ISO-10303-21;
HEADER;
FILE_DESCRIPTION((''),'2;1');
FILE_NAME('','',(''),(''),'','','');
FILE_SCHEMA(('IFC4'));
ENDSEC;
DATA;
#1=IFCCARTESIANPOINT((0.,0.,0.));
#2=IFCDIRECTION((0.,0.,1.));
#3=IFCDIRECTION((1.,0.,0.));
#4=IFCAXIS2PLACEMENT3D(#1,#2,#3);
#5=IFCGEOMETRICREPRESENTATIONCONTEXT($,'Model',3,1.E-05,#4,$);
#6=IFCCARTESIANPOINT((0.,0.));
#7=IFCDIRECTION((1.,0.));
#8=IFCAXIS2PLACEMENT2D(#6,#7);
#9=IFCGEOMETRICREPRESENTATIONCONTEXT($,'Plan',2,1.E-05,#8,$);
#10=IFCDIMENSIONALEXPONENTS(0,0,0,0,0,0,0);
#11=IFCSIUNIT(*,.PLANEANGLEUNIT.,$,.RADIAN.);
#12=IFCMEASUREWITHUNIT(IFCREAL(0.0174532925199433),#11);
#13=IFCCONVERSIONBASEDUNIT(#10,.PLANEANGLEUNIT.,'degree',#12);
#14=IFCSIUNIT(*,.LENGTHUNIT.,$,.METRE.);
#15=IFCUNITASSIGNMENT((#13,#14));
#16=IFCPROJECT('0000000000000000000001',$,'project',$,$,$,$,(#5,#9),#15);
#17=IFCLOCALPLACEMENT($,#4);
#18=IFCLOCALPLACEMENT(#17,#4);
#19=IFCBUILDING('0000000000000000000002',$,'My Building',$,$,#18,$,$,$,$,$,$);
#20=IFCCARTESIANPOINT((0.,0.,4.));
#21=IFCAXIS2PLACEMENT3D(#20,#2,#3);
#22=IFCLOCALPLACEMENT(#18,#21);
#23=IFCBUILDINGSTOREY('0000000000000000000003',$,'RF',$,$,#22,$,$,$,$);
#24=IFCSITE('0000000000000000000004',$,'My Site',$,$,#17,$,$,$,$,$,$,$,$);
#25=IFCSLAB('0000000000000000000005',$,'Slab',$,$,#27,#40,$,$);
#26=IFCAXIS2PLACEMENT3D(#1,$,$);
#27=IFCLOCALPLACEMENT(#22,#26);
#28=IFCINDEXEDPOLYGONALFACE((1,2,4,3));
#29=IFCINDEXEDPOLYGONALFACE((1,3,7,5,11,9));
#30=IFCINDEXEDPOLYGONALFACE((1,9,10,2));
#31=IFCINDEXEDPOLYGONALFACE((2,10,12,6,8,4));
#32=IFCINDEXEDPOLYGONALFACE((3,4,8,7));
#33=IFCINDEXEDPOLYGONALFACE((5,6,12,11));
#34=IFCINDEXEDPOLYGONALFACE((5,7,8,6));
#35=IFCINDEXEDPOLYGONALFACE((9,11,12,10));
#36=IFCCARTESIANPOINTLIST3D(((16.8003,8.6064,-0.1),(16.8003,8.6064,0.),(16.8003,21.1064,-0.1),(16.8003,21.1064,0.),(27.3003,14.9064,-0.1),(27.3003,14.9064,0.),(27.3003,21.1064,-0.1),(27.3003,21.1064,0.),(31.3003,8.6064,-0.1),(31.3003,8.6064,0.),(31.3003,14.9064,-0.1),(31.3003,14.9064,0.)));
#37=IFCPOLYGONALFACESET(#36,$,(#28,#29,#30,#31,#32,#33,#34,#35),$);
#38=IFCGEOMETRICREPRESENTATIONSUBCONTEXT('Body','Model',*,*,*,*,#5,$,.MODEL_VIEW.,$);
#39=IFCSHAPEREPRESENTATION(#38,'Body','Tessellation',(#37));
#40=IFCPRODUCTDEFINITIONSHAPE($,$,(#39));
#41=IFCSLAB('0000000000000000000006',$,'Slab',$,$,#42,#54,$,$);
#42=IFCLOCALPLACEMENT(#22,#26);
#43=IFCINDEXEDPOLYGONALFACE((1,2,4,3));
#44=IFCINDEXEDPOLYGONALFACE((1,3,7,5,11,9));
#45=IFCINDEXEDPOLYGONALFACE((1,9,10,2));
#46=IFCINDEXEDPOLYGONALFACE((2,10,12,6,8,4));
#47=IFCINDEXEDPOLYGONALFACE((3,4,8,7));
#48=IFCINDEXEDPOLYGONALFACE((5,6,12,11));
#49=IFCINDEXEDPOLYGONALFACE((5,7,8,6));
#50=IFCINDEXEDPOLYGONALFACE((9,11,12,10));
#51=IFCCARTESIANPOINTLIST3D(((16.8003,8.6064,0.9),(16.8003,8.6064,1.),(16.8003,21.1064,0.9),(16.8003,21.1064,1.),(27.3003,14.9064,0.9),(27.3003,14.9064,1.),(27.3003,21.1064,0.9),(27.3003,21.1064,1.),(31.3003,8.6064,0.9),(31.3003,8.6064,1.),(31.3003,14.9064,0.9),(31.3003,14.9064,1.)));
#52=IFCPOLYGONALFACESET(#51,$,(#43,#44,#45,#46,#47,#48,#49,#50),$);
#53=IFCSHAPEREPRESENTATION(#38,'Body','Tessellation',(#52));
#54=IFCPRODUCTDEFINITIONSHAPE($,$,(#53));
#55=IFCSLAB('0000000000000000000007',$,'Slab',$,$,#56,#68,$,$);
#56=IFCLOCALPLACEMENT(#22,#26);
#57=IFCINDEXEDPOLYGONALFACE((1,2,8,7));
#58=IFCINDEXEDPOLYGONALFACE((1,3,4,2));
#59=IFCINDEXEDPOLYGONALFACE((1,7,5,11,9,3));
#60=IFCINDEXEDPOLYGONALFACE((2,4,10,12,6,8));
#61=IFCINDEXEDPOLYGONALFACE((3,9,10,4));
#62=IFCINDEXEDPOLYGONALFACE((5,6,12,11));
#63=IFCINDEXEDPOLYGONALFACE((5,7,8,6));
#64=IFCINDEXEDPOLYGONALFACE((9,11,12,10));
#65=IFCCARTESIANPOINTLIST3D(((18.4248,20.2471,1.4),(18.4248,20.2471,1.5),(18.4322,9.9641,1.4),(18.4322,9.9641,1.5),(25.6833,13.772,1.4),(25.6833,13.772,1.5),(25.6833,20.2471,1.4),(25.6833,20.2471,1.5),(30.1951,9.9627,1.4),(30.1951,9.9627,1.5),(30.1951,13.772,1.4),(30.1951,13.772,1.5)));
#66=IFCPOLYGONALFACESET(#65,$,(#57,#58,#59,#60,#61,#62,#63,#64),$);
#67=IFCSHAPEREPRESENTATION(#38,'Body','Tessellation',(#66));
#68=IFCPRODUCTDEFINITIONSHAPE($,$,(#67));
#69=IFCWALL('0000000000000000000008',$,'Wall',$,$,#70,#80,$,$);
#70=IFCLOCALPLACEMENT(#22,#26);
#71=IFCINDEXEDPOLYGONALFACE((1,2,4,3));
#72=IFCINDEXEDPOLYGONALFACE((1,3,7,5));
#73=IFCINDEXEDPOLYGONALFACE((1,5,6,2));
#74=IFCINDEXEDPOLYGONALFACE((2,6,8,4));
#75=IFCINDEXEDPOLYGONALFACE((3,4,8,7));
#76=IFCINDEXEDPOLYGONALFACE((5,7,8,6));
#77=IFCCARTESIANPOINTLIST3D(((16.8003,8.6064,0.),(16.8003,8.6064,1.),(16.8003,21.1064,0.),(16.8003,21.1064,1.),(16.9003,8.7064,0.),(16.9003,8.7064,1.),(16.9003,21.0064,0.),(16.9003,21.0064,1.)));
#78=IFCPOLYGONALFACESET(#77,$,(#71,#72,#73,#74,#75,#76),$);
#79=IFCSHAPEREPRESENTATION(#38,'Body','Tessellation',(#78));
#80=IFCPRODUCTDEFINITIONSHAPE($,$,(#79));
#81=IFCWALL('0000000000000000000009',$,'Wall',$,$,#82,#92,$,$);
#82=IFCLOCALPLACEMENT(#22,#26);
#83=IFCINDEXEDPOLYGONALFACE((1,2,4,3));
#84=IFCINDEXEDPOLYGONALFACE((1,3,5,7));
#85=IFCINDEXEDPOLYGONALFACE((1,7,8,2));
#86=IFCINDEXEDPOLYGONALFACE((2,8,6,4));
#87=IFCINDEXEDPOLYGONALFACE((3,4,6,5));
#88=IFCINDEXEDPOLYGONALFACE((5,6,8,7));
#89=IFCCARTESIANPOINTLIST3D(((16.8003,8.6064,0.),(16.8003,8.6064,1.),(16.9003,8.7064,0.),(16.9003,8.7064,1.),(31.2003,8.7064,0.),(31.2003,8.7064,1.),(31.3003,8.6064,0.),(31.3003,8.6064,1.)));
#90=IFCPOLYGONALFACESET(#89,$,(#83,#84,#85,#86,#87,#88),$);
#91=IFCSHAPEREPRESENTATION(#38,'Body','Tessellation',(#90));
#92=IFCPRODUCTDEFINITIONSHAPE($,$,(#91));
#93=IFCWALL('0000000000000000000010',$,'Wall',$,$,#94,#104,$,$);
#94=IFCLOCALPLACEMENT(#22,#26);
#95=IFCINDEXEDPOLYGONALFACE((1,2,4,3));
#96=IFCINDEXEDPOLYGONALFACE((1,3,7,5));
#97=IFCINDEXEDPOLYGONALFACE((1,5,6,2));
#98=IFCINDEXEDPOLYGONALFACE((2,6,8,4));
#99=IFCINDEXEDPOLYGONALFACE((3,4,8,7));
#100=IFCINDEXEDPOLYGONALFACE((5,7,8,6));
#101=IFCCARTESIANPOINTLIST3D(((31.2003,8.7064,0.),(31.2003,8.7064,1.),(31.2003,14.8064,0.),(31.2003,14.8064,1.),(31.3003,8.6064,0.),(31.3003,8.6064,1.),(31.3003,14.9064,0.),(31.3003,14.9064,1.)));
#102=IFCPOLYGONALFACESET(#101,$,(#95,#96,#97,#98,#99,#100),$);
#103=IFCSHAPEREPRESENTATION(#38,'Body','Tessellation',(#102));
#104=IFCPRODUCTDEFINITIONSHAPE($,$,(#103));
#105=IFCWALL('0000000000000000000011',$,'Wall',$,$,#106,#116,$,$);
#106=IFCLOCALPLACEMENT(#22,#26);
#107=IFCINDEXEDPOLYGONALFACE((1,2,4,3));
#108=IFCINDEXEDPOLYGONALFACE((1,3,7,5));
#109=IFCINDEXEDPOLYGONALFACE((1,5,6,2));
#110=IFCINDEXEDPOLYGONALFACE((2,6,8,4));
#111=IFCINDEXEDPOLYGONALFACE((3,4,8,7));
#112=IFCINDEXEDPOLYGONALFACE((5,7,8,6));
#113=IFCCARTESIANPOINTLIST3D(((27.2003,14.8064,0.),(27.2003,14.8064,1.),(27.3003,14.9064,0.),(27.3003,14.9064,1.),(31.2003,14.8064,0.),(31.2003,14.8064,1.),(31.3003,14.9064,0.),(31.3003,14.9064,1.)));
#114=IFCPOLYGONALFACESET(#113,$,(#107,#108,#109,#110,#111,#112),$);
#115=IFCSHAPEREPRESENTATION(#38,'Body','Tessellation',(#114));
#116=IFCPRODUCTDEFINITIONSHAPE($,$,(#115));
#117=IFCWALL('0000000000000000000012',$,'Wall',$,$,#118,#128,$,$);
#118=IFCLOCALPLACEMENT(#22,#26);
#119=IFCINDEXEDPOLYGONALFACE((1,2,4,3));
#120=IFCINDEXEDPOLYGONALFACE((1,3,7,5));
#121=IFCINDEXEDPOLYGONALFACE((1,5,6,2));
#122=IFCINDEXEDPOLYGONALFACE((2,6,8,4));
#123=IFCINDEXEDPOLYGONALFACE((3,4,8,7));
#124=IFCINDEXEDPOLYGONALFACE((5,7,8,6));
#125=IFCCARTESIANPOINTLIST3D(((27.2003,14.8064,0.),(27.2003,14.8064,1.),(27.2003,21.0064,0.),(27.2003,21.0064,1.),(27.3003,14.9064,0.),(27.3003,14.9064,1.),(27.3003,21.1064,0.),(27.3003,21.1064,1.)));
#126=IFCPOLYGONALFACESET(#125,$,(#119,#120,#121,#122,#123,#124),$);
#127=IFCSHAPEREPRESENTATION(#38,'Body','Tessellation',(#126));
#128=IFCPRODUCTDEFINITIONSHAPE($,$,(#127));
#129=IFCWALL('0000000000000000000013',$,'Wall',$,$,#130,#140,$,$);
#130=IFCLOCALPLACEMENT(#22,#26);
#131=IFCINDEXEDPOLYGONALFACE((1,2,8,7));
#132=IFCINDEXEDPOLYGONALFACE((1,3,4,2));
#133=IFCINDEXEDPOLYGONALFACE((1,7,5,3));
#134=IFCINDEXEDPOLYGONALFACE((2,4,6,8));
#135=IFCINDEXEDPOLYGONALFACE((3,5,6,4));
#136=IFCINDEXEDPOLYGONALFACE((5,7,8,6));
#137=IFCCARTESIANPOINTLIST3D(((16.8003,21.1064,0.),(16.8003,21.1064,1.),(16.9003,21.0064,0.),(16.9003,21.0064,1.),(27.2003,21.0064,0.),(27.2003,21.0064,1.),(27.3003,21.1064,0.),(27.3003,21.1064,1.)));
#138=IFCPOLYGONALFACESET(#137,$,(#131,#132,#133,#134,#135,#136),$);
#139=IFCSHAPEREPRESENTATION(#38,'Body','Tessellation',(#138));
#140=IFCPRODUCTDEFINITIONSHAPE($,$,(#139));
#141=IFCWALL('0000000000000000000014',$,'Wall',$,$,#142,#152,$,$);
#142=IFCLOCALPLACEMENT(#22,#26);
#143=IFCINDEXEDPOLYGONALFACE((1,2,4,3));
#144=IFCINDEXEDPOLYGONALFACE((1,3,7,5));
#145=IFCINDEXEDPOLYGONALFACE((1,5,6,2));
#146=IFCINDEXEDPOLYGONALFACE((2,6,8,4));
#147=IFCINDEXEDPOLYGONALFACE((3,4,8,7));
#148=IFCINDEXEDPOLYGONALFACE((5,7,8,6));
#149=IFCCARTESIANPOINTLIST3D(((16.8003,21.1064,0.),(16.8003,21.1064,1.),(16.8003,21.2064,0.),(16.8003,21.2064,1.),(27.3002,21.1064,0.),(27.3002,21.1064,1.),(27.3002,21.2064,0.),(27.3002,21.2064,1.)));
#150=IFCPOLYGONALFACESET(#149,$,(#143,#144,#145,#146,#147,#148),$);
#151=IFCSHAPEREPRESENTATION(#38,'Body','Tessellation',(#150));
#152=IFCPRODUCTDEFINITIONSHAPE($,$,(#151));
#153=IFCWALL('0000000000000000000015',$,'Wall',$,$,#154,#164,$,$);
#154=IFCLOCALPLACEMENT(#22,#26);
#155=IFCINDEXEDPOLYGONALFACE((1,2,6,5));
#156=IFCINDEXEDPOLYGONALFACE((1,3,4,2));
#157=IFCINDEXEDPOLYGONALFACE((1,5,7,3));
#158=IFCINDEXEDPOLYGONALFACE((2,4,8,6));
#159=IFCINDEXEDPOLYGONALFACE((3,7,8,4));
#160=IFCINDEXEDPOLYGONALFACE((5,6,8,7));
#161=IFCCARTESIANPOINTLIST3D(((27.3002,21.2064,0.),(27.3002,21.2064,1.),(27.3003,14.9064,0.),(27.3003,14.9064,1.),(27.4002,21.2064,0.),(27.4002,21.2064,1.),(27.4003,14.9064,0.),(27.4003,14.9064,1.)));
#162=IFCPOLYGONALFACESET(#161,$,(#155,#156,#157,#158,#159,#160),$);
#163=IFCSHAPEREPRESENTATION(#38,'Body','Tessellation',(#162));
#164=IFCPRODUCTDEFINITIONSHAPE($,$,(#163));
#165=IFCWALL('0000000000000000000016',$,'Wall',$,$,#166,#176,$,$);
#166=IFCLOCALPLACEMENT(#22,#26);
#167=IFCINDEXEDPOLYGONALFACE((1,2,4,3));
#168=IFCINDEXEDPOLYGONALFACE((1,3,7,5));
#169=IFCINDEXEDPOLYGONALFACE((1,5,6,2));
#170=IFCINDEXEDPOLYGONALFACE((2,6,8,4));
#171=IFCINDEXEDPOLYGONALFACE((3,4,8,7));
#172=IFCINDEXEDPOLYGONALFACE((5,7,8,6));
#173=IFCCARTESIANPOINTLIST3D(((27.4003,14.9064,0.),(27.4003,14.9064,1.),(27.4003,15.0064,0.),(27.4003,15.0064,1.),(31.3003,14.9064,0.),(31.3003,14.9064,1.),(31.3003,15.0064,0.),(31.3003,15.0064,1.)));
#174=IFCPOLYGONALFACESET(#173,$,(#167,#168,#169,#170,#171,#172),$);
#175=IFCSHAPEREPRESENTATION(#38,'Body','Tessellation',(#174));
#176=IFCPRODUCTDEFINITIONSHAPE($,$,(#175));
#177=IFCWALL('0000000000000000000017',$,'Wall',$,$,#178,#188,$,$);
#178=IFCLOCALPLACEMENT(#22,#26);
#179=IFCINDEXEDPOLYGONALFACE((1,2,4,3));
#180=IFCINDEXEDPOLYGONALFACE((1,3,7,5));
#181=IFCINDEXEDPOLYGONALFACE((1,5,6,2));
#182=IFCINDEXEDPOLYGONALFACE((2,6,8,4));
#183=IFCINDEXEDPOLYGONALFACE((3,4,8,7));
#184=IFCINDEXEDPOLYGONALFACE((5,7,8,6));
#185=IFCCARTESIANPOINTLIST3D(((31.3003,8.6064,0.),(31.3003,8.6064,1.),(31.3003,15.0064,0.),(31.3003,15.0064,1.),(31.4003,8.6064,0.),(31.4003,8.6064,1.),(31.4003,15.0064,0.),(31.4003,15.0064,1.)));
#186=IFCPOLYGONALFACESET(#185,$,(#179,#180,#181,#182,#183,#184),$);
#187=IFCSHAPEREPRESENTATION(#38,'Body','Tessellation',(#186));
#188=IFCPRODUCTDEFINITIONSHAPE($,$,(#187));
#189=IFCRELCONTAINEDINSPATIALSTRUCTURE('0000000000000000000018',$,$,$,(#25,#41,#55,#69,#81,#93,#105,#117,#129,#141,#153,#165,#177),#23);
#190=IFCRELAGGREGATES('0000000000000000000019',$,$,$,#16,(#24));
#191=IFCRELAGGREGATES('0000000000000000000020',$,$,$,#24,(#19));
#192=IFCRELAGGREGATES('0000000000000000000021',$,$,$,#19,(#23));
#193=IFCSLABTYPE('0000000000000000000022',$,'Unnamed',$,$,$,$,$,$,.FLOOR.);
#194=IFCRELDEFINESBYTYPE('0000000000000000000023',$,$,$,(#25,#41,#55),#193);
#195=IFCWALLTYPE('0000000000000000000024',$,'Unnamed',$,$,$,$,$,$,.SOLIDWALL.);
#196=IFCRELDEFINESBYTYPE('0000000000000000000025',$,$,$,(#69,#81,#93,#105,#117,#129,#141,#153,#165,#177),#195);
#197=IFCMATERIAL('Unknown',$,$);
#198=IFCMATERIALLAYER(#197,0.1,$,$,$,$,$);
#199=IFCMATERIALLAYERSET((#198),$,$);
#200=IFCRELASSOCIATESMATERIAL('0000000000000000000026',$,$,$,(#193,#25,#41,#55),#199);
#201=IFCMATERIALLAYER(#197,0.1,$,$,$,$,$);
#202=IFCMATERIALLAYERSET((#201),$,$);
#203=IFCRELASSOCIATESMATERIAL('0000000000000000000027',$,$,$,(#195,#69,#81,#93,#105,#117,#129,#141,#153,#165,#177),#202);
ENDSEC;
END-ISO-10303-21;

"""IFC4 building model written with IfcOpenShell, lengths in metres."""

from ifc_helpers import new_model, entity, si_unit, converted_unit, frame, origin_with_axes, origin_2d_with_axis, place, context, subcontext, project, spatial, line, indexed_curve, outline, extrude, material, layer, layer_set, layer_usage, type_object, element, save


model = new_model("IFC4")

# Units and contexts
model_context = context("Model", 3, precision=1e-05, world=origin_with_axes())
plan_context = context("Plan", 2, precision=1e-05, world=origin_2d_with_axis())
body_context = subcontext(model_context, "Body", "Model", "MODEL_VIEW")
ifc_project = project(units=[converted_unit("PLANEANGLEUNIT", "degree", entity("IfcReal", 0.0174532925199433), si_unit("PLANEANGLEUNIT", "RADIAN"), dimensions=[0, 0, 0, 0, 0, 0, 0]), si_unit("LENGTHUNIT", "METRE")], contexts=[model_context, plan_context])

# Site, building, storey
site_placement = place(None, origin_with_axes())
site = spatial("IfcSite", under=ifc_project, at=site_placement, Name="My Site")
building_placement = place(site_placement, origin_with_axes())
building = spatial("IfcBuilding", under=site, at=building_placement, Name="My Building")
storey_placement = place(building_placement, frame((0.0, 0.0, 4.0), z_axis=(0.0, 0.0, 1.0), x_axis=(1.0, 0.0, 0.0)))
storey = spatial("IfcBuildingStorey", under=building, at=storey_placement, Name="RF")

# Slabs
ifc_material = material(Name="Unknown")
ifc_layer_1 = layer(ifc_material, 0.1)
ifc_layer_set_1 = layer_set([ifc_layer_1])
ifc_layer_usage_1 = layer_usage(ifc_layer_set_1, "AXIS3", "POSITIVE", -0.1)
slab_type = type_object("IfcSlabType", Name="Unnamed", PredefinedType="FLOOR", material=ifc_layer_set_1)
slab_1_placement = place(storey_placement, frame((16.8003, 21.1064, 0.0), z_axis=(0.0, 0.0, 1.0), x_axis=(1.0, 0.0, 0.0)))
element("IfcSlab", 1, at=slab_1_placement, inside=storey, type_object=slab_type, material=ifc_layer_usage_1, Name="Slab", context=body_context, shape_type="SweptSolid", body=[
    extrude(outline(indexed_curve([(0.0, 0.0), (10.5, 0.0), (10.5, -6.2), (14.5, -6.2), (14.5, -12.5), (0.0, -12.5), (0.0, 0.0)])), frame((0.0, 0.0, -0.1), z_axis=(0.0, 0.0, 1.0), x_axis=(1.0, 0.0, 0.0)), (0.0, 0.0, 1.0), 0.1),
])
ifc_layer_usage_2 = layer_usage(ifc_layer_set_1, "AXIS3", "POSITIVE", -0.1)
slab_2_placement = place(storey_placement, frame((16.8003, 21.1064, 1.0), z_axis=(0.0, 0.0, 1.0), x_axis=(1.0, 0.0, 0.0)))
element("IfcSlab", 2, at=slab_2_placement, inside=storey, type_object=slab_type, material=ifc_layer_usage_2, Name="Slab", context=body_context, shape_type="SweptSolid", body=[
    extrude(outline(indexed_curve([(0.0, 0.0), (10.5, 0.0), (10.5, -6.2), (14.5, -6.2), (14.5, -12.5), (0.0, -12.5), (0.0, 0.0)])), frame((0.0, 0.0, -0.1), z_axis=(0.0, 0.0, 1.0), x_axis=(1.0, 0.0, 0.0)), (0.0, 0.0, 1.0), 0.1),
])
ifc_layer_usage_3 = layer_usage(ifc_layer_set_1, "AXIS3", "POSITIVE", -0.1)
slab_3_placement = place(storey_placement, frame((18.4248, 20.2471, 1.5), z_axis=(0.0, 0.0, 1.0), x_axis=(1.0, 0.0, 0.0)))
element("IfcSlab", 3, at=slab_3_placement, inside=storey, type_object=slab_type, material=ifc_layer_usage_3, Name="Slab", context=body_context, shape_type="SweptSolid", body=[
    extrude(outline(indexed_curve([(0.0, 0.0), (7.2584, 0.0), (7.2584, -6.4751), (11.7702, -6.4751), (11.7702, -10.2844), (0.0074, -10.283), (0.0, 0.0)])), frame((0.0, 0.0, -0.1), z_axis=(0.0, 0.0, 1.0), x_axis=(1.0, 0.0, 0.0)), (0.0, 0.0, 1.0), 0.1),
])

# Walls
ifc_layer_2 = layer(ifc_material, 0.1)
ifc_layer_set_2 = layer_set([ifc_layer_2])
ifc_layer_usage_4 = layer_usage(ifc_layer_set_2, "AXIS2", "POSITIVE", 0.0)
wall_type = type_object("IfcWallType", Name="Unnamed", PredefinedType="SOLIDWALL", material=ifc_layer_set_2)
wall_1_placement = place(storey_placement, frame((16.8003, 21.1064, 0.0), z_axis=(0.0, 0.0, 1.0), x_axis=(0.0, -1.0, 0.0)))
element("IfcWall", 4, at=wall_1_placement, inside=storey, type_object=wall_type, material=ifc_layer_usage_4, Name="Wall", context=body_context, shape_type="SweptSolid", body=[
    extrude(outline(indexed_curve([(0.0, 0.0), (0.1, 0.1), (12.4, 0.1), (12.5, 0.0)], segments=[line(1, 2, 3, 4, 1)])), origin_with_axes(), (0.0, 0.0, 1.0), 1.0),
])
ifc_layer_usage_5 = layer_usage(ifc_layer_set_2, "AXIS2", "POSITIVE", 0.0)
wall_2_placement = place(storey_placement, frame((16.8003, 8.6064, 0.0), z_axis=(0.0, 0.0, 1.0), x_axis=(1.0, 0.0, 0.0)))
element("IfcWall", 5, at=wall_2_placement, inside=storey, type_object=wall_type, material=ifc_layer_usage_5, Name="Wall", context=body_context, shape_type="SweptSolid", body=[
    extrude(outline(indexed_curve([(0.0, 0.0), (0.1, 0.1), (14.4, 0.1), (14.5, 0.0)], segments=[line(1, 2, 3, 4, 1)])), origin_with_axes(), (0.0, 0.0, 1.0), 1.0),
])
ifc_layer_usage_6 = layer_usage(ifc_layer_set_2, "AXIS2", "POSITIVE", 0.0)
wall_3_placement = place(storey_placement, frame((31.3003, 8.6064, 0.0), z_axis=(0.0, 0.0, 1.0), x_axis=(0.0, 1.0, 0.0)))
element("IfcWall", 6, at=wall_3_placement, inside=storey, type_object=wall_type, material=ifc_layer_usage_6, Name="Wall", context=body_context, shape_type="SweptSolid", body=[
    extrude(outline(indexed_curve([(0.0, 0.0), (0.1, 0.1), (6.2, 0.1), (6.3, 0.0)], segments=[line(1, 2, 3, 4, 1)])), origin_with_axes(), (0.0, 0.0, 1.0), 1.0),
])
ifc_layer_usage_7 = layer_usage(ifc_layer_set_2, "AXIS2", "POSITIVE", 0.0)
wall_4_placement = place(storey_placement, frame((31.3003, 14.9064, 0.0), z_axis=(0.0, 0.0, 1.0), x_axis=(-1.0, 0.0, 0.0)))
element("IfcWall", 7, at=wall_4_placement, inside=storey, type_object=wall_type, material=ifc_layer_usage_7, Name="Wall", context=body_context, shape_type="SweptSolid", body=[
    extrude(outline(indexed_curve([(0.0, 0.0), (0.1, 0.1), (4.1, 0.1), (4.0, 0.0)], segments=[line(1, 2, 3, 4, 1)])), origin_with_axes(), (0.0, 0.0, 1.0), 1.0),
])
ifc_layer_usage_8 = layer_usage(ifc_layer_set_2, "AXIS2", "POSITIVE", 0.0)
wall_5_placement = place(storey_placement, frame((27.3003, 14.9064, 0.0), z_axis=(0.0, 0.0, 1.0), x_axis=(0.0, 1.0, 0.0)))
element("IfcWall", 8, at=wall_5_placement, inside=storey, type_object=wall_type, material=ifc_layer_usage_8, Name="Wall", context=body_context, shape_type="SweptSolid", body=[
    extrude(outline(indexed_curve([(0.0, 0.0), (-0.1, 0.1), (6.1, 0.1), (6.2, 0.0)], segments=[line(1, 2, 3, 4, 1)])), origin_with_axes(), (0.0, 0.0, 1.0), 1.0),
])
ifc_layer_usage_9 = layer_usage(ifc_layer_set_2, "AXIS2", "POSITIVE", 0.0)
wall_6_placement = place(storey_placement, frame((27.3003, 21.1064, 0.0), z_axis=(0.0, 0.0, 1.0), x_axis=(-1.0, 0.0, 0.0)))
element("IfcWall", 9, at=wall_6_placement, inside=storey, type_object=wall_type, material=ifc_layer_usage_9, Name="Wall", context=body_context, shape_type="SweptSolid", body=[
    extrude(outline(indexed_curve([(0.0, 0.0), (0.1, 0.1), (10.4, 0.1), (10.5, 0.0)], segments=[line(1, 2, 3, 4, 1)])), origin_with_axes(), (0.0, 0.0, 1.0), 1.0),
])
ifc_layer_usage_10 = layer_usage(ifc_layer_set_2, "AXIS2", "POSITIVE", 0.0)
wall_7_placement = place(storey_placement, frame((16.8003, 21.1064, 0.0), z_axis=(0.0, 0.0, 1.0), x_axis=(1.0, 0.0, 0.0)))
element("IfcWall", 10, at=wall_7_placement, inside=storey, type_object=wall_type, material=ifc_layer_usage_10, Name="Wall", context=body_context, shape_type="SweptSolid", body=[
    extrude(outline(indexed_curve([(0.0, 0.0), (0.0, 0.1), (10.4999, 0.1), (10.4999, 0.0)], segments=[line(1, 2, 3, 4, 1)])), origin_with_axes(), (0.0, 0.0, 1.0), 1.0),
])
ifc_layer_usage_11 = layer_usage(ifc_layer_set_2, "AXIS2", "POSITIVE", 0.0)
wall_8_placement = place(storey_placement, frame((27.3002, 21.2064, 0.0), z_axis=(0.0, 0.0, 1.0), x_axis=(0.000012, -1.0, 0.0)))
element("IfcWall", 11, at=wall_8_placement, inside=storey, type_object=wall_type, material=ifc_layer_usage_11, Name="Wall", context=body_context, shape_type="SweptSolid", body=[
    extrude(outline(indexed_curve([(0.0, 0.0), (0.0, 0.1), (6.3, 0.1), (6.3, 0.0)], segments=[line(1, 2, 3, 4, 1)])), origin_with_axes(), (0.0, 0.0, 1.0), 1.0),
])
ifc_layer_usage_12 = layer_usage(ifc_layer_set_2, "AXIS2", "POSITIVE", 0.0)
wall_9_placement = place(storey_placement, frame((27.4003, 14.9064, 0.0), z_axis=(0.0, 0.0, 1.0), x_axis=(1.0, 0.0, 0.0)))
element("IfcWall", 12, at=wall_9_placement, inside=storey, type_object=wall_type, material=ifc_layer_usage_12, Name="Wall", context=body_context, shape_type="SweptSolid", body=[
    extrude(outline(indexed_curve([(0.0, 0.0), (0.0, 0.1), (3.9, 0.1), (3.9, 0.0)], segments=[line(1, 2, 3, 4, 1)])), origin_with_axes(), (0.0, 0.0, 1.0), 1.0),
])
ifc_layer_usage_13 = layer_usage(ifc_layer_set_2, "AXIS2", "POSITIVE", 0.0)
wall_10_placement = place(storey_placement, frame((31.3003, 15.0064, 0.0), z_axis=(0.0, 0.0, 1.0), x_axis=(0.0, -1.0, 0.0)))
element("IfcWall", 13, at=wall_10_placement, inside=storey, type_object=wall_type, material=ifc_layer_usage_13, Name="Wall", context=body_context, shape_type="SweptSolid", body=[
    extrude(outline(indexed_curve([(0.0, 0.0), (0.0, 0.1), (6.4, 0.1), (6.4, 0.0)], segments=[line(1, 2, 3, 4, 1)])), origin_with_axes(), (0.0, 0.0, 1.0), 1.0),
])

save(model, "model.ifc")
